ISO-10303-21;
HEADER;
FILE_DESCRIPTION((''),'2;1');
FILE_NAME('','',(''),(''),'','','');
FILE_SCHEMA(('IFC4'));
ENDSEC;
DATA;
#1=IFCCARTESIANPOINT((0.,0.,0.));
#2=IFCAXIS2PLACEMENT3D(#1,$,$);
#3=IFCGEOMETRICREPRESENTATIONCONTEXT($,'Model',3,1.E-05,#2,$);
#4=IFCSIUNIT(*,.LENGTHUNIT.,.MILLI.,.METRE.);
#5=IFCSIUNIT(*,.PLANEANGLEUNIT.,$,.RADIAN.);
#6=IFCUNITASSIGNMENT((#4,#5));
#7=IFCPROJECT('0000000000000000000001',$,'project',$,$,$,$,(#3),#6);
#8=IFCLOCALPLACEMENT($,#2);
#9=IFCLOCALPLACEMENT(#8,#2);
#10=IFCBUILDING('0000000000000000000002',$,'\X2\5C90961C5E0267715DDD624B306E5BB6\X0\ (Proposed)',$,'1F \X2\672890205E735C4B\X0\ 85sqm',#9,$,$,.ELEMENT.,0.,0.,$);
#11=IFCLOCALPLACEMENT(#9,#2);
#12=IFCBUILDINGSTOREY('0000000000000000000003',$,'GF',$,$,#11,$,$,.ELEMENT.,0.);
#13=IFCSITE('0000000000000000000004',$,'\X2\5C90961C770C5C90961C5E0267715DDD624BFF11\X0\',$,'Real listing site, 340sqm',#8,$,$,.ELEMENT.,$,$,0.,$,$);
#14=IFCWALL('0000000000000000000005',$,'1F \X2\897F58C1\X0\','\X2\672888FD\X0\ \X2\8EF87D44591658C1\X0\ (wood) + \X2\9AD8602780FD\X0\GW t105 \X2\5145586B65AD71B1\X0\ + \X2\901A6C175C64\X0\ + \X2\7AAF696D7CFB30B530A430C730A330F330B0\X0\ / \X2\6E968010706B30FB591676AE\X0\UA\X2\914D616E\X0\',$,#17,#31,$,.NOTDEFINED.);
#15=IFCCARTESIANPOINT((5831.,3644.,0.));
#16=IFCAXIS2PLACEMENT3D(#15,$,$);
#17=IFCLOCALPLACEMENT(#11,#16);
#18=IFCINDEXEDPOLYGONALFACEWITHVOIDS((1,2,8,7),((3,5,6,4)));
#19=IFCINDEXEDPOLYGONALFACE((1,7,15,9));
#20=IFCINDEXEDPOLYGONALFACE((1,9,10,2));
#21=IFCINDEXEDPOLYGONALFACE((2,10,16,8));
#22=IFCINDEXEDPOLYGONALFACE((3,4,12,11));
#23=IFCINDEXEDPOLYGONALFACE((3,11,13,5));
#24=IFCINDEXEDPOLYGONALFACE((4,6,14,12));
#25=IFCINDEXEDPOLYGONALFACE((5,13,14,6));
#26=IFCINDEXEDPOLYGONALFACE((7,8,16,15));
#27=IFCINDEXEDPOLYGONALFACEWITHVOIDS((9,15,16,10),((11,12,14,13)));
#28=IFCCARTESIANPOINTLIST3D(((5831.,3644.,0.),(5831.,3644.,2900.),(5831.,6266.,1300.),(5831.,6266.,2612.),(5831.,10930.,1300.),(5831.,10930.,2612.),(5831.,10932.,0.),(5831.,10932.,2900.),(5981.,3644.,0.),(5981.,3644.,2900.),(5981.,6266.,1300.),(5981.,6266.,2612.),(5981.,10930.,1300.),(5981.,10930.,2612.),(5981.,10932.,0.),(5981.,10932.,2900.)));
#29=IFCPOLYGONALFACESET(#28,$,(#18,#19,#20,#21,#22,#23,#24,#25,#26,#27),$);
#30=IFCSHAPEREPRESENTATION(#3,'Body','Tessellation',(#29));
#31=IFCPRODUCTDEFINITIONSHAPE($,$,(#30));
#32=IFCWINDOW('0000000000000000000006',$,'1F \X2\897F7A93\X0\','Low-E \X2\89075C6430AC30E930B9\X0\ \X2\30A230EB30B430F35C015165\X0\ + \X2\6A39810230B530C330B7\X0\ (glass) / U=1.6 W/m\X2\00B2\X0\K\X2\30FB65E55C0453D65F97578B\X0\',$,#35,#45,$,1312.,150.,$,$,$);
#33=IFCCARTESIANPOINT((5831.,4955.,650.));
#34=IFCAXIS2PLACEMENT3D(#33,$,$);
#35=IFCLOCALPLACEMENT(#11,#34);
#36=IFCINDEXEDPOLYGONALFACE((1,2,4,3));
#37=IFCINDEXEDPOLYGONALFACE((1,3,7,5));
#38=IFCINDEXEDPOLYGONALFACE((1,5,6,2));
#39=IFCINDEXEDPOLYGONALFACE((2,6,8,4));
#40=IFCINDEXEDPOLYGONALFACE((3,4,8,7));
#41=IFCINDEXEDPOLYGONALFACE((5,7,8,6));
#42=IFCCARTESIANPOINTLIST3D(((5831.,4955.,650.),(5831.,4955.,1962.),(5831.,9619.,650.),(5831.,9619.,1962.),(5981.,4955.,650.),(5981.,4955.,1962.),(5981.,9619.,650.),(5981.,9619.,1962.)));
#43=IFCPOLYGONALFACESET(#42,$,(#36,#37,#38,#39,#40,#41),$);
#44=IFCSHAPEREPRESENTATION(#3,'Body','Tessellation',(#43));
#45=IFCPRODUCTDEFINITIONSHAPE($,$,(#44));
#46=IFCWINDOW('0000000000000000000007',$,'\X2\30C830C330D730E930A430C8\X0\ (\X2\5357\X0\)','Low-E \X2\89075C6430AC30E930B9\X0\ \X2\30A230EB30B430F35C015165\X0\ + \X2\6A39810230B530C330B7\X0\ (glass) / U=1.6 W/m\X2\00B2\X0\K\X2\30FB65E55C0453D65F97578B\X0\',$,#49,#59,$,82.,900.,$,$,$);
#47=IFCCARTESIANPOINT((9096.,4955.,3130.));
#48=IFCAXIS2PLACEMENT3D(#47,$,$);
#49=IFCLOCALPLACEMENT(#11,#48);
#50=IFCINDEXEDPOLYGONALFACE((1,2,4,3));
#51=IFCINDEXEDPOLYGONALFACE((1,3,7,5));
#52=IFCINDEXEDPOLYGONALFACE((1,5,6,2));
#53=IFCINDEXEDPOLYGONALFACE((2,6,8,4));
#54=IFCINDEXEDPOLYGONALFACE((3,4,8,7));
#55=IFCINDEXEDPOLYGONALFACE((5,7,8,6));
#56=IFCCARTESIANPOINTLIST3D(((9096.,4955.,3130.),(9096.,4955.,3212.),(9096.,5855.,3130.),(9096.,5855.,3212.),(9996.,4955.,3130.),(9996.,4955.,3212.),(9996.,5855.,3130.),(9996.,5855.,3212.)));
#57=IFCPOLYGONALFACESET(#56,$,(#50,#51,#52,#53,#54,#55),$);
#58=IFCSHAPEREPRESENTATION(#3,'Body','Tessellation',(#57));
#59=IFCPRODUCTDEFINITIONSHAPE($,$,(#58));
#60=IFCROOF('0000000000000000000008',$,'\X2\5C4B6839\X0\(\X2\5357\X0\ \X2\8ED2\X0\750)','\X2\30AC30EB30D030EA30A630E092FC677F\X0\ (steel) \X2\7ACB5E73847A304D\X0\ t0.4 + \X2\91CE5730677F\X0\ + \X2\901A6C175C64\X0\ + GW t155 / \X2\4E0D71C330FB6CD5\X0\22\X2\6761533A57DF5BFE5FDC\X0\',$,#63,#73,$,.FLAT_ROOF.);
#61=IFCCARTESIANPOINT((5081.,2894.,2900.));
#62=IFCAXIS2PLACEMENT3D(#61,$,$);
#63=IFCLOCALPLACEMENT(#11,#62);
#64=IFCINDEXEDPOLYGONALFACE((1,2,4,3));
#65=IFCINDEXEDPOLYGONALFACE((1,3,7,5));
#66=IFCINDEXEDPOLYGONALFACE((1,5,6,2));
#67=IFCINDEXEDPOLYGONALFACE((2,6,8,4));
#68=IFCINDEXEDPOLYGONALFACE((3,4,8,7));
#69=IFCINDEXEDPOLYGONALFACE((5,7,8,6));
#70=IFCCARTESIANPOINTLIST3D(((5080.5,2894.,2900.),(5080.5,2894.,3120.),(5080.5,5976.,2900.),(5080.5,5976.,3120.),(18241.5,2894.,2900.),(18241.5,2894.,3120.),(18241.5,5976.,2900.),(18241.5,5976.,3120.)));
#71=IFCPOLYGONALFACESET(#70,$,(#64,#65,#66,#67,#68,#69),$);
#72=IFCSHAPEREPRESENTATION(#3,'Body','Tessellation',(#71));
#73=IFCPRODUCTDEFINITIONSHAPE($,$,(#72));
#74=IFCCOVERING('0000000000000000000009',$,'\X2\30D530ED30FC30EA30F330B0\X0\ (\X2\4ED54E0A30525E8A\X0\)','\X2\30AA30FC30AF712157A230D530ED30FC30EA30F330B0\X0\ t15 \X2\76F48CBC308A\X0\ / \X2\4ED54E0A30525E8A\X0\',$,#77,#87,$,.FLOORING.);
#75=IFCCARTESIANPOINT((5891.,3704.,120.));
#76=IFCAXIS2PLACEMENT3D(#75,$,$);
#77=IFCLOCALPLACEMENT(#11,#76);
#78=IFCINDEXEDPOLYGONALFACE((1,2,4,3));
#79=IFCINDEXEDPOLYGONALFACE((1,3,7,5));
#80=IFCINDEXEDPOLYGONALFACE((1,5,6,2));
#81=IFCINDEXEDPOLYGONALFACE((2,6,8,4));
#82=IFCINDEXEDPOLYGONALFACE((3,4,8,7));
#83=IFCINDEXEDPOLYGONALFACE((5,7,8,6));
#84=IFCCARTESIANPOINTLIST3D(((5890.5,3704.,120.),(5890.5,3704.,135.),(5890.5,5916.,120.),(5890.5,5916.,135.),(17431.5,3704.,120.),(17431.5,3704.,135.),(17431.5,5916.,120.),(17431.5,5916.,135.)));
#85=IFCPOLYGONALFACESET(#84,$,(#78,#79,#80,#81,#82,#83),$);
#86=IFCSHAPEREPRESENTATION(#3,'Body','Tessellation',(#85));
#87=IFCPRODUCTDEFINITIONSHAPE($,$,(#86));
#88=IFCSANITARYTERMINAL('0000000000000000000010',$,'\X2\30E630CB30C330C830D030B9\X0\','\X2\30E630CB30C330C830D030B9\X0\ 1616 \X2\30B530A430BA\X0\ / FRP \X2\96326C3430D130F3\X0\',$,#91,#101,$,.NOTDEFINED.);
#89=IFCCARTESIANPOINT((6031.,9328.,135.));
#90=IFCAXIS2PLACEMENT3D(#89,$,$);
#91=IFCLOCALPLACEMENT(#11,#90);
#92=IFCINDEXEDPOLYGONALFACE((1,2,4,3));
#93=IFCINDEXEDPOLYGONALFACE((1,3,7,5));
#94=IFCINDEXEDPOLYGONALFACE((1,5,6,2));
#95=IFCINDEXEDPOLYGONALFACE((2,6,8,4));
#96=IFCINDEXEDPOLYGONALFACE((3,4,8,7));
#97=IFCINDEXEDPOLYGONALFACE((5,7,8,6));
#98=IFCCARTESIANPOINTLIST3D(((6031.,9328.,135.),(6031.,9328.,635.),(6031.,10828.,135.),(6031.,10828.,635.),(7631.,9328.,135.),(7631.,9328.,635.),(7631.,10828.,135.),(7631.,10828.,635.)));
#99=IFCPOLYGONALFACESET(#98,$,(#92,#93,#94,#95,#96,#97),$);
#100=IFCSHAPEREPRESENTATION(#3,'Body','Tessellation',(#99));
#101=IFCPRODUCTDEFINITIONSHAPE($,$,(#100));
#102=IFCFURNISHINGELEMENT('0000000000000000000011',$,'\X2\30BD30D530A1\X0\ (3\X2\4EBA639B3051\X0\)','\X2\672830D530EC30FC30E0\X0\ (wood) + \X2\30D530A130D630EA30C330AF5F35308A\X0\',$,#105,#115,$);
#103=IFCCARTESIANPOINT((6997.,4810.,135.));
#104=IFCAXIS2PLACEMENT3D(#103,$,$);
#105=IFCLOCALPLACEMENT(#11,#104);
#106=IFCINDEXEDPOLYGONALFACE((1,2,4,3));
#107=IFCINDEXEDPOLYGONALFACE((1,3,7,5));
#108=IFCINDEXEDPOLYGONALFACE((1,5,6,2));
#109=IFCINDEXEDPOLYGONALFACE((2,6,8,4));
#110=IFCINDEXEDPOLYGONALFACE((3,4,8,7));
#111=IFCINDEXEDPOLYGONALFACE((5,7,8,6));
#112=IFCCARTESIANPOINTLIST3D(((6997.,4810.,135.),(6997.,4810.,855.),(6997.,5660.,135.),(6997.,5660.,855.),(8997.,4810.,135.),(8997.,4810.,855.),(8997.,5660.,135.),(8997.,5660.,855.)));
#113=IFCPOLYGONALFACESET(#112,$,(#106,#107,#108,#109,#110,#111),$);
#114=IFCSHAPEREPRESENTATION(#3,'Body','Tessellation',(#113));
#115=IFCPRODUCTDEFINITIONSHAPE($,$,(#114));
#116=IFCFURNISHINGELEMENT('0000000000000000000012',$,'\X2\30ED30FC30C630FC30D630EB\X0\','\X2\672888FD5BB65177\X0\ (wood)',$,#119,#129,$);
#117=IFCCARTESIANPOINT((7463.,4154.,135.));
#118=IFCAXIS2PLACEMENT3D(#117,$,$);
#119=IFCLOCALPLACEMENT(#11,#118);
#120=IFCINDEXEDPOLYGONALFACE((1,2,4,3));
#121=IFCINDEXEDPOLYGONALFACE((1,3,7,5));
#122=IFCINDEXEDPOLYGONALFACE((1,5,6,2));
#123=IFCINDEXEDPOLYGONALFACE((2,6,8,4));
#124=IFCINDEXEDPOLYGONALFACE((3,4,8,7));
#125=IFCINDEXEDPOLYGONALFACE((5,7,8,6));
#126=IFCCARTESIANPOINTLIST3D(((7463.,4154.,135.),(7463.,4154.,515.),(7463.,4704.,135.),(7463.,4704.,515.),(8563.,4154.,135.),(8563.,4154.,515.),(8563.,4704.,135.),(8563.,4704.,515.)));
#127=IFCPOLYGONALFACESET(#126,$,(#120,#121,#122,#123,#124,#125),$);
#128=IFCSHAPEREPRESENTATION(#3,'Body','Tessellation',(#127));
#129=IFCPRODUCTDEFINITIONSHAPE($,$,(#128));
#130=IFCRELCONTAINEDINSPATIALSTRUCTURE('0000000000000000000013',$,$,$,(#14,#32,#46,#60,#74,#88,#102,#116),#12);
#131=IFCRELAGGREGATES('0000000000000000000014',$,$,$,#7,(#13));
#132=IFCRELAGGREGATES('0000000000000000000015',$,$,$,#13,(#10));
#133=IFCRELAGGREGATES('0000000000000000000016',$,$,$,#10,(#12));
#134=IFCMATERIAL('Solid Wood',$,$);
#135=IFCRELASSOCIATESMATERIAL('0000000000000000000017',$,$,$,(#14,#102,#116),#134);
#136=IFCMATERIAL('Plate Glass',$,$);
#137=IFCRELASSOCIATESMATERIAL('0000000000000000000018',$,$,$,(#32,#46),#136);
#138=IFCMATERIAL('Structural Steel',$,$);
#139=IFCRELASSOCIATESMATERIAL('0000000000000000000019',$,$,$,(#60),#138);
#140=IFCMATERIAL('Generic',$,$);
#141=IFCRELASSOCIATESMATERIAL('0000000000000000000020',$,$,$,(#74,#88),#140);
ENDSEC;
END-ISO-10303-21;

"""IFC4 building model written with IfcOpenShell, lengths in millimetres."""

from ifc_helpers import new_model, si_unit, frame, frame_2d, origin, place, context, project, spatial, rectangle, extrude, material, element, fill, save


model = new_model("IFC4")

# Units and contexts
model_context = context("Model", 3, precision=1e-05, world=origin())
ifc_project = project(units=[si_unit("LENGTHUNIT", "METRE", prefix="MILLI"), si_unit("PLANEANGLEUNIT", "RADIAN")], contexts=[model_context])

# Site, building, storey
site_placement = place(None, origin())
site = spatial("IfcSite", under=ifc_project, at=site_placement, Name="岐阜県岐阜市東川手１", ObjectType="Real listing site, 340sqm", CompositionType="ELEMENT", RefElevation=0.0)
building_placement = place(site_placement, origin())
building = spatial("IfcBuilding", under=site, at=building_placement, Name="岐阜市東川手の家 (Proposed)", ObjectType="1F 木造平屋 85sqm", CompositionType="ELEMENT", ElevationOfRefHeight=0.0, ElevationOfTerrain=0.0)
storey_placement = place(building_placement, origin())
storey = spatial("IfcBuildingStorey", under=building, at=storey_placement, Name="GF", CompositionType="ELEMENT", Elevation=0.0)

# Shared definitions
ifc_material_1 = material(Name="Solid Wood")

# Shared definitions
ifc_material_2 = material(Name="Plate Glass")

# Wall, opening, window
wall_1_placement = place(storey_placement, frame((5831.0, 3644.0, 0.0)))
wall_1 = element("IfcWall", 1, at=wall_1_placement, inside=storey, material=ifc_material_1, Name="1F 西壁", Description="木製 軸組外壁 (wood) + 高性能GW t105 充填断熱 + 通気層 + 窯業系サイディング / 準耐火・外皮UA配慮", PredefinedType="NOTDEFINED", context=model_context, shape_type="SweptSolid", body=[
    extrude(rectangle(XDim=150.0, YDim=7288.0, at=frame_2d((75.0, 3644.0))), frame((5831.0, 3644.0, 0.0)), (0.0, 0.0, 1.0), 2900.0),
])
opening_1_placement = place(storey_placement, frame((5831.0, 4955.0, 650.0)))
opening_1 = element("IfcOpeningElement", 2, at=opening_1_placement, cuts=wall_1, PredefinedType="NOTDEFINED", context=model_context, shape_type="SweptSolid", body=[
    extrude(rectangle(XDim=150.0, YDim=4664.0, at=frame_2d((75.0, 2332.0))), frame((5831.0, 4955.0, 650.0)), (0.0, 0.0, 1.0), 1312.0),
])
window_1_placement = place(storey_placement, frame((5831.0, 4955.0, 650.0)))
window_1 = element("IfcWindow", 3, at=window_1_placement, inside=storey, material=ifc_material_2, Name="1F 西窓", Description="Low-E 複層ガラス アルゴン封入 + 樹脂サッシ (glass) / U=1.6 W/m²K・日射取得型", OverallHeight=1312.0, OverallWidth=150.0, context=model_context, shape_type="SweptSolid", body=[
    extrude(rectangle(XDim=150.0, YDim=4664.0, at=frame_2d((75.0, 2332.0))), frame((5831.0, 4955.0, 650.0)), (0.0, 0.0, 1.0), 1312.0),
])
fill(opening_1, window_1)

# Window
window_2_placement = place(storey_placement, frame((9096.0, 4955.0, 3130.0)))
element("IfcWindow", 4, at=window_2_placement, inside=storey, material=ifc_material_2, Name="トップライト (南)", Description="Low-E 複層ガラス アルゴン封入 + 樹脂サッシ (glass) / U=1.6 W/m²K・日射取得型", OverallHeight=82.0, OverallWidth=900.0, context=model_context, shape_type="SweptSolid", body=[
    extrude(rectangle(XDim=900.0, YDim=900.0, at=frame_2d((450.0, 450.0))), frame((9096.0, 4955.0, 3130.0)), (0.0, 0.0, 1.0), 82.0),
])

# Roof
ifc_material_3 = material(Name="Structural Steel")
roof_1_placement = place(storey_placement, frame((5081.0, 2894.0, 2900.0)))
element("IfcRoof", 5, at=roof_1_placement, inside=storey, material=ifc_material_3, Name="屋根(南 軒750)", Description="ガルバリウム鋼板 (steel) 立平葺き t0.4 + 野地板 + 通気層 + GW t155 / 不燃・法22条区域対応", PredefinedType="FLAT_ROOF", context=model_context, shape_type="SweptSolid", body=[
    extrude(rectangle(XDim=13161.0, YDim=3082.0, at=frame_2d((6580.0, 1541.0))), frame((5081.0, 2894.0, 2900.0)), (0.0, 0.0, 1.0), 220.0),
])

# Covering
ifc_material_4 = material(Name="Generic")
covering_1_placement = place(storey_placement, frame((5891.0, 3704.0, 120.0)))
element("IfcCovering", 6, at=covering_1_placement, inside=storey, material=ifc_material_4, Name="フローリング (仕上げ床)", Description="オーク無垢フローリング t15 直貼り / 仕上げ床", PredefinedType="FLOORING", context=model_context, shape_type="SweptSolid", body=[
    extrude(rectangle(XDim=11541.0, YDim=2212.0, at=frame_2d((5770.0, 1106.0))), frame((5891.0, 3704.0, 120.0)), (0.0, 0.0, 1.0), 15.0),
])

# Sanitary terminal
sanitary_terminal_placement = place(storey_placement, frame((6031.0, 9328.0, 135.0)))
element("IfcSanitaryTerminal", 7, at=sanitary_terminal_placement, inside=storey, material=ifc_material_4, Name="ユニットバス", Description="ユニットバス 1616 サイズ / FRP 防水パン", PredefinedType="NOTDEFINED", context=model_context, shape_type="SweptSolid", body=[
    extrude(rectangle(XDim=1600.0, YDim=1500.0, at=frame_2d((800.0, 750.0))), frame((6031.0, 9328.0, 135.0)), (0.0, 0.0, 1.0), 500.0),
])

# Furnishing elements
furnishing_1_placement = place(storey_placement, frame((6997.0, 4810.0, 135.0)))
element("IfcFurnishingElement", 8, at=furnishing_1_placement, inside=storey, material=ifc_material_1, Name="ソファ (3人掛け)", Description="木フレーム (wood) + ファブリック張り", context=model_context, shape_type="SweptSolid", body=[
    extrude(rectangle(XDim=2000.0, YDim=850.0, at=frame_2d((1000.0, 425.0))), frame((6997.0, 4810.0, 135.0)), (0.0, 0.0, 1.0), 720.0),
])
furnishing_2_placement = place(storey_placement, frame((7463.0, 4154.0, 135.0)))
element("IfcFurnishingElement", 9, at=furnishing_2_placement, inside=storey, material=ifc_material_1, Name="ローテーブル", Description="木製家具 (wood)", context=model_context, shape_type="SweptSolid", body=[
    extrude(rectangle(XDim=1100.0, YDim=550.0, at=frame_2d((550.0, 275.0))), frame((7463.0, 4154.0, 135.0)), (0.0, 0.0, 1.0), 380.0),
])

save(model, "model.ifc")
